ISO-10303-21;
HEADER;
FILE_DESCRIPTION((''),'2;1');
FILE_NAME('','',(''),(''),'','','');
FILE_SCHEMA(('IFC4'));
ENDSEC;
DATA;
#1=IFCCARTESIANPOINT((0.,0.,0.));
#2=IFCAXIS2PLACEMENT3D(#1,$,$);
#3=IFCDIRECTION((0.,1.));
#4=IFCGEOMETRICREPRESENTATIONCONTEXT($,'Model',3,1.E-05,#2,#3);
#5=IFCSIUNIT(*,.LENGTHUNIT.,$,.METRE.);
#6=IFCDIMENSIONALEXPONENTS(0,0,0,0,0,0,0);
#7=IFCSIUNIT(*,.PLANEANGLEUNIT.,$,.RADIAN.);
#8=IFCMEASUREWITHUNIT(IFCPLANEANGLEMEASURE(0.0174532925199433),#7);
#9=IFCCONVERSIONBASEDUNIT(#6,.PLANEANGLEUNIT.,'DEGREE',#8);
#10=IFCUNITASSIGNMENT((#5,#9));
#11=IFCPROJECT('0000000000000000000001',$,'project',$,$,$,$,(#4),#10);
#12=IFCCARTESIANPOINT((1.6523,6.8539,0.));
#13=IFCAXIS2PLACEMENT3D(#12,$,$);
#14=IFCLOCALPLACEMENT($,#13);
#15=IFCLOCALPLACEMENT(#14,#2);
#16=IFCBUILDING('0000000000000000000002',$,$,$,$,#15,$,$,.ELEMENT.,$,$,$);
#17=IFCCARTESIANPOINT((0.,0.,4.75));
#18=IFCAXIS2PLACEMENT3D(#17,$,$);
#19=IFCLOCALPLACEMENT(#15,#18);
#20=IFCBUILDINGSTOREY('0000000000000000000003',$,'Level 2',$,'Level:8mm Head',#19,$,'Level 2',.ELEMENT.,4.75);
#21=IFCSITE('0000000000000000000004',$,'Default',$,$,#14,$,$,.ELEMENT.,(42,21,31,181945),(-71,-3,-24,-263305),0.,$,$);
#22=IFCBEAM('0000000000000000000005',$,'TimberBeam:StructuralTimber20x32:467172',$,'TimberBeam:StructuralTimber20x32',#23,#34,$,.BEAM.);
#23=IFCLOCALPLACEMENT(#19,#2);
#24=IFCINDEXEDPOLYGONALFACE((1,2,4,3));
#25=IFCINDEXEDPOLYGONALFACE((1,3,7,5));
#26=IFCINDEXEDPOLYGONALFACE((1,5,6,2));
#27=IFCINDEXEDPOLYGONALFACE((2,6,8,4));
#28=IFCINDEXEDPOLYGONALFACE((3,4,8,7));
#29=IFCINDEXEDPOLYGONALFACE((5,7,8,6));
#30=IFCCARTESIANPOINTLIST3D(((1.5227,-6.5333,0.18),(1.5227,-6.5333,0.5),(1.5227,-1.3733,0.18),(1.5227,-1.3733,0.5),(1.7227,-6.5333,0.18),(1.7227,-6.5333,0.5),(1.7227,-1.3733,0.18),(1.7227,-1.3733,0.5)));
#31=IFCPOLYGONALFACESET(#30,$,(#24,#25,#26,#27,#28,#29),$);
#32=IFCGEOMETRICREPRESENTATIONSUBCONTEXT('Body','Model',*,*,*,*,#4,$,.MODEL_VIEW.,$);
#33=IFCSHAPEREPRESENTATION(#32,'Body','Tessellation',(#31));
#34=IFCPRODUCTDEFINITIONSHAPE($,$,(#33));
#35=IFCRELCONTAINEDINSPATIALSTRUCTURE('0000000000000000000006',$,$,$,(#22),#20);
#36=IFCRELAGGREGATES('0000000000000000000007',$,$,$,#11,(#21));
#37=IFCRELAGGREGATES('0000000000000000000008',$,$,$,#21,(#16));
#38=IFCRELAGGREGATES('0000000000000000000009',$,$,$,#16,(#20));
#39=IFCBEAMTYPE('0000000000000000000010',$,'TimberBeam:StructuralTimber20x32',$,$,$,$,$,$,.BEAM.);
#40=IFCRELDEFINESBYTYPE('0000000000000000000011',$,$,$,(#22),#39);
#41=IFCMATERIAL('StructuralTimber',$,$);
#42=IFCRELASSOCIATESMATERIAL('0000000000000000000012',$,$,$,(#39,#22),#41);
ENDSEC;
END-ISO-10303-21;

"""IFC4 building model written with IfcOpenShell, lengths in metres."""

from ifc_helpers import new_model, entity, si_unit, converted_unit, direction, frame, origin, place, context, subcontext, project, spatial, indexed_curve, outline, extrude, source, transform, mapped, material, type_object, type_shapes, element, save


model = new_model("IFC4")

# Units and contexts
model_context = context("Model", 3, precision=1e-05, world=origin(), true_north=direction((0.0, 1.0)))
body_context = subcontext(model_context, "Body", "Model", "MODEL_VIEW")
ifc_project = project(units=[si_unit("LENGTHUNIT", "METRE"), converted_unit("PLANEANGLEUNIT", "DEGREE", entity("IfcPlaneAngleMeasure", 0.0174532925199433), si_unit("PLANEANGLEUNIT", "RADIAN"), dimensions=[0, 0, 0, 0, 0, 0, 0])], contexts=[model_context])

# Site, building, storey
site_placement = place(None, frame((1.6523, 6.8539, 0.0)))
site = spatial("IfcSite", under=ifc_project, at=site_placement, Name="Default", CompositionType="ELEMENT", RefLatitude=(42, 21, 31, 181945), RefLongitude=(-71, -3, -24, -263305), RefElevation=0.0)
building_placement = place(site_placement, origin())
building = spatial("IfcBuilding", under=site, at=building_placement, CompositionType="ELEMENT")
storey_placement = place(building_placement, frame((0.0, 0.0, 4.75)))
storey = spatial("IfcBuildingStorey", under=building, at=storey_placement, Name="Level 2", ObjectType="Level:8mm Head", LongName="Level 2", CompositionType="ELEMENT", Elevation=4.75)

# Beam
ifc_material = material(Name="StructuralTimber")
beam_type = type_object("IfcBeamType", Name="TimberBeam:StructuralTimber20x32", PredefinedType="BEAM", material=ifc_material)
shared_shape = source(origin(), body_context, "Body", "SweptSolid", [
    extrude(outline(indexed_curve([(-2.58, -0.1), (2.58, -0.1), (2.58, 0.1), (-2.58, 0.1), (-2.58, -0.1)], self_intersect=False)), frame((0.0, 0.0, -0.16), z_axis=(0.0, 0.0, 1.0), x_axis=(-1.0, 0.0, 0.0)), (0.0, 0.0, 1.0), 0.32),
])
type_shapes(beam_type, [shared_shape])
beam_placement = place(storey_placement, frame((1.6227, -3.9533, 0.34), z_axis=(0.0, 0.0, 1.0), x_axis=(0.0, -1.0, 0.0)))
element("IfcBeam", 1, at=beam_placement, inside=storey, type_object=beam_type, material=ifc_material, Name="TimberBeam:StructuralTimber20x32:467172", ObjectType="TimberBeam:StructuralTimber20x32", PredefinedType="BEAM", context=body_context, shape_type="MappedRepresentation", body=[
    mapped(shared_shape, transform((0.0, 0.0, 0.0), scale=1.0)),
])

save(model, "model.ifc")
